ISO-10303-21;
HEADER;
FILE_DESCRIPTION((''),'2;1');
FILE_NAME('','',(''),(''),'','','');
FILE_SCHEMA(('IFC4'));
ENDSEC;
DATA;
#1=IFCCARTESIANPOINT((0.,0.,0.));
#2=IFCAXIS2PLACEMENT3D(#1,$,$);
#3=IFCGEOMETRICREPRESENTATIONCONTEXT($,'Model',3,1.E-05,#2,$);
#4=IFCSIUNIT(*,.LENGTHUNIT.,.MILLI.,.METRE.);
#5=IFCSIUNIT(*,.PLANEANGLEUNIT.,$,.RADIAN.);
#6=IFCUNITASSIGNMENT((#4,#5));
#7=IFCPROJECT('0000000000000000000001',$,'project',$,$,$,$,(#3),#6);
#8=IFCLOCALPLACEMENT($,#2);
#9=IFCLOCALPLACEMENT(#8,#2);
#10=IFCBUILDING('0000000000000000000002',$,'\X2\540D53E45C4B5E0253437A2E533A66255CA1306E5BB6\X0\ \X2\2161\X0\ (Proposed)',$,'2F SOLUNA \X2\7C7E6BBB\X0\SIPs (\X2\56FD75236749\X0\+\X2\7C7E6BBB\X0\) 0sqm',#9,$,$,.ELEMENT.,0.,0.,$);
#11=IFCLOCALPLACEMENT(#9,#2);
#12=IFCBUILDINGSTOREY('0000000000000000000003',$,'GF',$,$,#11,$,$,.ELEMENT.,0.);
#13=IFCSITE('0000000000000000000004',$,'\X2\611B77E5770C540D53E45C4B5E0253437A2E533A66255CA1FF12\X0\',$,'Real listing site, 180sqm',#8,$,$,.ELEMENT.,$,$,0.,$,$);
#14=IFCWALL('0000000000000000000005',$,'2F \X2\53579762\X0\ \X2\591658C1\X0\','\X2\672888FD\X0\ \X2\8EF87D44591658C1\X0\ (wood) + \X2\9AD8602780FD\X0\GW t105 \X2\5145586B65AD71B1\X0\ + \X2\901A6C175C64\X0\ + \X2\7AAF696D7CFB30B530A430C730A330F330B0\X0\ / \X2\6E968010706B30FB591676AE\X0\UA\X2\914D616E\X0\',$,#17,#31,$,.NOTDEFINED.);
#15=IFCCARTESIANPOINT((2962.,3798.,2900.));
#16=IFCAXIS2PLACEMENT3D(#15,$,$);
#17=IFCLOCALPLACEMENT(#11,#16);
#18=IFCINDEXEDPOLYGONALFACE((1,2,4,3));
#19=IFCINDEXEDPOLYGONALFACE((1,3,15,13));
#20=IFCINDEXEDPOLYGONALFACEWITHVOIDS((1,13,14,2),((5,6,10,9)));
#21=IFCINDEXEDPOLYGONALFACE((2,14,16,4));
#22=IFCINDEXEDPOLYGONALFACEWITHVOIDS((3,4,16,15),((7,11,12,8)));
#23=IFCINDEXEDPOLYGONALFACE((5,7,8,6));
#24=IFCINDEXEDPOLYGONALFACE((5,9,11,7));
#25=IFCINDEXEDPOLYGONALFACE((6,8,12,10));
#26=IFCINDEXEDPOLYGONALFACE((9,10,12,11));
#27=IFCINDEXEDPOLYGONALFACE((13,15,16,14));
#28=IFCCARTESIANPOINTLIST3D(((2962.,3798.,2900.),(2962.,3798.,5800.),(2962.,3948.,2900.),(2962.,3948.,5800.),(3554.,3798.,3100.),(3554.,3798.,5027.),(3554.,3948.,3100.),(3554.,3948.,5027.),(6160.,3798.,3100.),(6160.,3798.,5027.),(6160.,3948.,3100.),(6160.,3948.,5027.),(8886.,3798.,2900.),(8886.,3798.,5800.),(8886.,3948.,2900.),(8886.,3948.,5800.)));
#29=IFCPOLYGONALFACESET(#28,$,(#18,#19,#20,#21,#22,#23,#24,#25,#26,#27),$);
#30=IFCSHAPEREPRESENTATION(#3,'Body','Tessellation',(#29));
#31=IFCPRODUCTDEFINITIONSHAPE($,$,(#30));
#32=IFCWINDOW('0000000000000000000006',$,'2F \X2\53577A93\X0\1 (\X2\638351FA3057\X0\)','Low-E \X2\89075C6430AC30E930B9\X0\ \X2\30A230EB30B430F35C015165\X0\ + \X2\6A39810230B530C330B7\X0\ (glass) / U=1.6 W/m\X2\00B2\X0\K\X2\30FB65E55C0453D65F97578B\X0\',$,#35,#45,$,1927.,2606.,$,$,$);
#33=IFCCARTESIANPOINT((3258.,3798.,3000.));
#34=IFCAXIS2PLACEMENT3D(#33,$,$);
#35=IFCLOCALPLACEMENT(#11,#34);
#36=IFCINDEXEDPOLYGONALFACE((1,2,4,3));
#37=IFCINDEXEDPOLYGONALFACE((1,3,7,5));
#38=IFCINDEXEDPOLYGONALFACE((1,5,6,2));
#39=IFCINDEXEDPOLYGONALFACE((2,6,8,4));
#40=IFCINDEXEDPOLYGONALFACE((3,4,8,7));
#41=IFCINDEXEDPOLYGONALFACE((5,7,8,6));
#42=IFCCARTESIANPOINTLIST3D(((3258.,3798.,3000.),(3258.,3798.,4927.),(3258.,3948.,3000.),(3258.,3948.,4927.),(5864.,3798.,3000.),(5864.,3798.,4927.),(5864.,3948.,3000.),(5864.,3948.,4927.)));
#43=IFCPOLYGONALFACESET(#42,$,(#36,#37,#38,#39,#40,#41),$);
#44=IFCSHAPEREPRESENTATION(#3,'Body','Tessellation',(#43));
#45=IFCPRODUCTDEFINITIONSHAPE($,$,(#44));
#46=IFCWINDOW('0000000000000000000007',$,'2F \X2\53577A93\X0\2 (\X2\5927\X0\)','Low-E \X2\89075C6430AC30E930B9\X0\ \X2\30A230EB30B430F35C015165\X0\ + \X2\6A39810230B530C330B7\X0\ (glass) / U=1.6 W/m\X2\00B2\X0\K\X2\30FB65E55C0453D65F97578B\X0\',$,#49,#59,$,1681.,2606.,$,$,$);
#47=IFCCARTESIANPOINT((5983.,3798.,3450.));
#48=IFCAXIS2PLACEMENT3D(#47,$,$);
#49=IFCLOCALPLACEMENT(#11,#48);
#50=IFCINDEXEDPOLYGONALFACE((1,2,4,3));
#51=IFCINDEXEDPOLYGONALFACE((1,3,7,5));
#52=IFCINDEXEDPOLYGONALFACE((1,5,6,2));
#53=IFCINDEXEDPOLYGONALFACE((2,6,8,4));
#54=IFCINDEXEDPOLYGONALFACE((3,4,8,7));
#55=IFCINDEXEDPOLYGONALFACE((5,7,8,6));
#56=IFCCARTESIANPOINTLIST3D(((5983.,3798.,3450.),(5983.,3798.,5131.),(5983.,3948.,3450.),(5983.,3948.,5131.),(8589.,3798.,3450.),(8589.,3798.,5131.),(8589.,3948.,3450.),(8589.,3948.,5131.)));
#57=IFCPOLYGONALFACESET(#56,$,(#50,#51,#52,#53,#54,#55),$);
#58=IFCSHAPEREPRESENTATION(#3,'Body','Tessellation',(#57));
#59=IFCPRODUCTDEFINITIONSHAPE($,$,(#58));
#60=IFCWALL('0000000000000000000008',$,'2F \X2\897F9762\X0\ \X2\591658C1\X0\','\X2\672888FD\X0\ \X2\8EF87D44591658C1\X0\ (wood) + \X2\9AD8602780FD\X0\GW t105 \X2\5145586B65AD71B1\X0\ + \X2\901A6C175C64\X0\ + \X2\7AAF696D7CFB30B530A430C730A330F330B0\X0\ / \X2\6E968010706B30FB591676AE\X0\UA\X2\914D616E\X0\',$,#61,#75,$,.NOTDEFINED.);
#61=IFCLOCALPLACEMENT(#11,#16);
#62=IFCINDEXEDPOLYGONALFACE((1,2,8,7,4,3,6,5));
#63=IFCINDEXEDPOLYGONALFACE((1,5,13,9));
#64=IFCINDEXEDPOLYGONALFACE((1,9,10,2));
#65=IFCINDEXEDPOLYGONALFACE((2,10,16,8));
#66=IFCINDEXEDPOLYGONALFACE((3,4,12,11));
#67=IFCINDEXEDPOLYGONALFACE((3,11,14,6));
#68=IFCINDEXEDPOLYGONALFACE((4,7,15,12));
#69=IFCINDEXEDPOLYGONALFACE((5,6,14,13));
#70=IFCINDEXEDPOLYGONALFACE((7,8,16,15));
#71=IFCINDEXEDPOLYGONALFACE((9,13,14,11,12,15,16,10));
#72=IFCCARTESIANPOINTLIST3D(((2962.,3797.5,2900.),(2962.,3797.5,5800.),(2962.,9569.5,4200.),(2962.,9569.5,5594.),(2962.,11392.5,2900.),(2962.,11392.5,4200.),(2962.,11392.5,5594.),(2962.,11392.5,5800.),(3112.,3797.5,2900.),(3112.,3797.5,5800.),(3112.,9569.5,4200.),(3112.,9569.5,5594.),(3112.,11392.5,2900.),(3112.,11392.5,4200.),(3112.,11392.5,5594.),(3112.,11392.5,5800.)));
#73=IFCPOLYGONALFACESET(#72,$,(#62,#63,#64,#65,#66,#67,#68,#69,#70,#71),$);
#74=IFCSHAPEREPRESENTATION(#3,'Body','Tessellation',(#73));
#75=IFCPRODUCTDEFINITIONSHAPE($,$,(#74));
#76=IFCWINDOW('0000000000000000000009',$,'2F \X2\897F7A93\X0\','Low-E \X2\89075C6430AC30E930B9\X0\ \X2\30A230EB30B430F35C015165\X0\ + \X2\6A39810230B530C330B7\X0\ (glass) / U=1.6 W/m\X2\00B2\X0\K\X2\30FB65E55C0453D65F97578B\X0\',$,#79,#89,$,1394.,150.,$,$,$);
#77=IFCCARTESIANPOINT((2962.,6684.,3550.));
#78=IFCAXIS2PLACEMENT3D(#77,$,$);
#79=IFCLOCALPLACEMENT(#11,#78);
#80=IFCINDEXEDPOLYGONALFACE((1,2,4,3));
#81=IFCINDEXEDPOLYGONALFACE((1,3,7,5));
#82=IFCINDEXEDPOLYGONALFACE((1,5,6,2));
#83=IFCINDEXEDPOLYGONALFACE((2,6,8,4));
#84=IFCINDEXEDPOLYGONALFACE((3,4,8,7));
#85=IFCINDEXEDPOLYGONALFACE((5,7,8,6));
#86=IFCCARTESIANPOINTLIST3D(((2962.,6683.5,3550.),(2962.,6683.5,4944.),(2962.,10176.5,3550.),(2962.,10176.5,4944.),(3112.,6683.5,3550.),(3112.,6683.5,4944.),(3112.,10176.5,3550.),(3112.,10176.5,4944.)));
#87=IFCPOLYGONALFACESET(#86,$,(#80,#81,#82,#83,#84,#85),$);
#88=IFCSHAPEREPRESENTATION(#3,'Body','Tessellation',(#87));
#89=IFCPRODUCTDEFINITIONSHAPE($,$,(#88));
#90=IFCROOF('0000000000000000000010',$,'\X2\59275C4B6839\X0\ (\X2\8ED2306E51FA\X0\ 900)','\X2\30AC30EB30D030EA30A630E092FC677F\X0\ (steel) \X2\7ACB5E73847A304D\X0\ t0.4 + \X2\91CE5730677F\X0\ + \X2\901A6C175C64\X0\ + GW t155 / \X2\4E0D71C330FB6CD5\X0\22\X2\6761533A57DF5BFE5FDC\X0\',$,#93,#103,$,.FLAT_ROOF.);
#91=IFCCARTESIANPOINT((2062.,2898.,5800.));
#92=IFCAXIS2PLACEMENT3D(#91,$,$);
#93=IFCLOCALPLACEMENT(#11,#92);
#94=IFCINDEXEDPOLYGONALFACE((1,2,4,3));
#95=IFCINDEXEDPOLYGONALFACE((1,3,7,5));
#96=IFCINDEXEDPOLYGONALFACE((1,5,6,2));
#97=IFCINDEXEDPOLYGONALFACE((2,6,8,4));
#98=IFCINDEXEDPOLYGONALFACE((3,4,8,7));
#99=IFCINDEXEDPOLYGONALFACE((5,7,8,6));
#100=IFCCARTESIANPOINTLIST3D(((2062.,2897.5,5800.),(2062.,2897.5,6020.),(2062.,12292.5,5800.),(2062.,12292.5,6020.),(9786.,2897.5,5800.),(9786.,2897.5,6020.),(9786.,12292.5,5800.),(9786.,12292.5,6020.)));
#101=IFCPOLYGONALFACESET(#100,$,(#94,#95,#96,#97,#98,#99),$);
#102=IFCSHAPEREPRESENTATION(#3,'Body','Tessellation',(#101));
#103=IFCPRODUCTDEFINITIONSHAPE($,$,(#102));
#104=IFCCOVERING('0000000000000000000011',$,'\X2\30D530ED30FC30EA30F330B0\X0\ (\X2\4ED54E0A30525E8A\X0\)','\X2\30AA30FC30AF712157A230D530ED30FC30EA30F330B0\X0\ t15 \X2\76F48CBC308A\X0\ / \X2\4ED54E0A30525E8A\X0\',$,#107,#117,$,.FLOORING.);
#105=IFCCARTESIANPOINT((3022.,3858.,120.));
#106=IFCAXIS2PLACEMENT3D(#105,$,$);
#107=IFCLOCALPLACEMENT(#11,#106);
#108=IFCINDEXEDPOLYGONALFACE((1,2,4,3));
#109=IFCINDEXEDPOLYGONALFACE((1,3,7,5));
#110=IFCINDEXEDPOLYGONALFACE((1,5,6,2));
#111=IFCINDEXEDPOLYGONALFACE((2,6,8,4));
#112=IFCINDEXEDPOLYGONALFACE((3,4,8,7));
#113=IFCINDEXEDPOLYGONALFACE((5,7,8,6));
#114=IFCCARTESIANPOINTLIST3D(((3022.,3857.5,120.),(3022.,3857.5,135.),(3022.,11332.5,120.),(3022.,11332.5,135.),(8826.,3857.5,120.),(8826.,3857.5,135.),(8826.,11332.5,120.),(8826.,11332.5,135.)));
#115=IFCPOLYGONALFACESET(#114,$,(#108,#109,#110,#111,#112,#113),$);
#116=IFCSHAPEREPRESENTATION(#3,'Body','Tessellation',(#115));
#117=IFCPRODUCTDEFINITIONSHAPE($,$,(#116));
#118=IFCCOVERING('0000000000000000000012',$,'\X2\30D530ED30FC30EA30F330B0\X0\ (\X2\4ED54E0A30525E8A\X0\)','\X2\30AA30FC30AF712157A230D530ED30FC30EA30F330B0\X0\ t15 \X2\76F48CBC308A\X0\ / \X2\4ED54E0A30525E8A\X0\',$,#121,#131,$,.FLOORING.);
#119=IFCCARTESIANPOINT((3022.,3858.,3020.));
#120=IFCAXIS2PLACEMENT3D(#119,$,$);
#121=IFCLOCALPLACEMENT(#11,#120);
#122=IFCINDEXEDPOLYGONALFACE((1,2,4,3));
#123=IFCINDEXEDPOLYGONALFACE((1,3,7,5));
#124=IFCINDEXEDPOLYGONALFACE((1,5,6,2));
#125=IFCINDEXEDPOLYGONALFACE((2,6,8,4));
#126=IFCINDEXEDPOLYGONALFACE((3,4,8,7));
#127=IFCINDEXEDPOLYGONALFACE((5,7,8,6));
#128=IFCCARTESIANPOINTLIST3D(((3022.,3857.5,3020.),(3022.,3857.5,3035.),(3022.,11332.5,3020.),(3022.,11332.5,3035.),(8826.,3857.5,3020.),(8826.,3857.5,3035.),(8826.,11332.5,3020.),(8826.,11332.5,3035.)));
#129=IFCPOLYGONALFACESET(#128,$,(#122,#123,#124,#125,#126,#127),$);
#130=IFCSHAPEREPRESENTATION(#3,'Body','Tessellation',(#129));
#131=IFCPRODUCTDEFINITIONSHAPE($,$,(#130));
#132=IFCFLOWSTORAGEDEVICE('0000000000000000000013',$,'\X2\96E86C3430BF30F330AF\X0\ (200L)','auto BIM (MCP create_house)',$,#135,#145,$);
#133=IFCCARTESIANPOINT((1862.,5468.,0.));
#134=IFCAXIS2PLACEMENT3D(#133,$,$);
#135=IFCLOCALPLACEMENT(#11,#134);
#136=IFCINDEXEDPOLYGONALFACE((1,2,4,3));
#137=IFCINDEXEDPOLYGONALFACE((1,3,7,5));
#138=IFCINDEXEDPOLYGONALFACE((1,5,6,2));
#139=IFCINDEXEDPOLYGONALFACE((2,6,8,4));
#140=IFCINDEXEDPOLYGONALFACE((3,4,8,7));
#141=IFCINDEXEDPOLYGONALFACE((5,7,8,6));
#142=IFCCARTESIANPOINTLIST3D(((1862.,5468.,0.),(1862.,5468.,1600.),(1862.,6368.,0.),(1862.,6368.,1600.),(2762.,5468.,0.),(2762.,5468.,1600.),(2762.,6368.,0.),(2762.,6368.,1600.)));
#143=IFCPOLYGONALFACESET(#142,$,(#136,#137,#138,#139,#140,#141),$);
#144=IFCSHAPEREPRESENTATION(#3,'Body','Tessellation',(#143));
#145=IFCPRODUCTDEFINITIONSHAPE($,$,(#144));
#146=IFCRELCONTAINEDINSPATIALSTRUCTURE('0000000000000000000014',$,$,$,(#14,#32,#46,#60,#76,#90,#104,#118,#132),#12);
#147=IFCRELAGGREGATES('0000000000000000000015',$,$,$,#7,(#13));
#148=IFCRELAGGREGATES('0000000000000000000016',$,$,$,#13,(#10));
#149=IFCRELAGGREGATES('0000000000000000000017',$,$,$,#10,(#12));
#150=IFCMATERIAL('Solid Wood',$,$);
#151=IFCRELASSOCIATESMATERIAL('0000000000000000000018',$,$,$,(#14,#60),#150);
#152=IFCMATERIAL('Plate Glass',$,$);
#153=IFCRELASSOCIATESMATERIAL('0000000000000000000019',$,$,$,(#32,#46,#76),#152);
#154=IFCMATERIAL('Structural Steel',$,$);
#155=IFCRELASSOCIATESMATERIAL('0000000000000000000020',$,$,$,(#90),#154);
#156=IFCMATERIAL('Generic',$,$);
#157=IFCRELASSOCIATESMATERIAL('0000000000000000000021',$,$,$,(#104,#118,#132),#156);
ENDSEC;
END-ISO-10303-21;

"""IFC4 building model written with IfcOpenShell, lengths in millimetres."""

from ifc_helpers import new_model, si_unit, frame, frame_2d, origin, place, context, project, spatial, rectangle, extrude, material, element, fill, save


model = new_model("IFC4")

# Units and contexts
model_context = context("Model", 3, precision=1e-05, world=origin())
ifc_project = project(units=[si_unit("LENGTHUNIT", "METRE", prefix="MILLI"), si_unit("PLANEANGLEUNIT", "RADIAN")], contexts=[model_context])

# Site, building, storey
site_placement = place(None, origin())
site = spatial("IfcSite", under=ifc_project, at=site_placement, Name="愛知県名古屋市千種区春岡２", ObjectType="Real listing site, 180sqm", CompositionType="ELEMENT", RefElevation=0.0)
building_placement = place(site_placement, origin())
building = spatial("IfcBuilding", under=site, at=building_placement, Name="名古屋市千種区春岡の家 Ⅱ (Proposed)", ObjectType="2F SOLUNA 籾殻SIPs (国産杉+籾殻) 0sqm", CompositionType="ELEMENT", ElevationOfRefHeight=0.0, ElevationOfTerrain=0.0)
storey_placement = place(building_placement, origin())
storey = spatial("IfcBuildingStorey", under=building, at=storey_placement, Name="GF", CompositionType="ELEMENT", Elevation=0.0)

# Shared definitions
ifc_material_1 = material(Name="Solid Wood")

# Shared definitions
ifc_material_2 = material(Name="Plate Glass")

# Wall, openings, windows
wall_1_placement = place(storey_placement, frame((2962.0, 3798.0, 2900.0)))
wall_1 = element("IfcWall", 1, at=wall_1_placement, inside=storey, material=ifc_material_1, Name="2F 南面 外壁", Description="木製 軸組外壁 (wood) + 高性能GW t105 充填断熱 + 通気層 + 窯業系サイディング / 準耐火・外皮UA配慮", PredefinedType="NOTDEFINED", context=model_context, shape_type="SweptSolid", body=[
    extrude(rectangle(XDim=5924.0, YDim=150.0, at=frame_2d((2962.0, 75.0))), frame((2962.0, 3798.0, 2900.0)), (0.0, 0.0, 1.0), 2900.0),
])
opening_1_placement = place(storey_placement, frame((3258.0, 3798.0, 3000.0)))
opening_1 = element("IfcOpeningElement", 2, at=opening_1_placement, cuts=wall_1, PredefinedType="NOTDEFINED", context=model_context, shape_type="SweptSolid", body=[
    extrude(rectangle(XDim=2606.0, YDim=150.0, at=frame_2d((1303.0, 75.0))), frame((3258.0, 3798.0, 3000.0)), (0.0, 0.0, 1.0), 1927.0),
])
opening_2_placement = place(storey_placement, frame((5983.0, 3798.0, 3450.0)))
opening_2 = element("IfcOpeningElement", 3, at=opening_2_placement, cuts=wall_1, PredefinedType="NOTDEFINED", context=model_context, shape_type="SweptSolid", body=[
    extrude(rectangle(XDim=2606.0, YDim=150.0, at=frame_2d((1303.0, 75.0))), frame((5983.0, 3798.0, 3450.0)), (0.0, 0.0, 1.0), 1681.0),
])
window_1_placement = place(storey_placement, frame((3258.0, 3798.0, 3000.0)))
window_1 = element("IfcWindow", 4, at=window_1_placement, inside=storey, material=ifc_material_2, Name="2F 南窓1 (掃出し)", Description="Low-E 複層ガラス アルゴン封入 + 樹脂サッシ (glass) / U=1.6 W/m²K・日射取得型", OverallHeight=1927.0, OverallWidth=2606.0, context=model_context, shape_type="SweptSolid", body=[
    extrude(rectangle(XDim=2606.0, YDim=150.0, at=frame_2d((1303.0, 75.0))), frame((3258.0, 3798.0, 3000.0)), (0.0, 0.0, 1.0), 1927.0),
])
fill(opening_1, window_1)
window_2_placement = place(storey_placement, frame((5983.0, 3798.0, 3450.0)))
window_2 = element("IfcWindow", 5, at=window_2_placement, inside=storey, material=ifc_material_2, Name="2F 南窓2 (大)", Description="Low-E 複層ガラス アルゴン封入 + 樹脂サッシ (glass) / U=1.6 W/m²K・日射取得型", OverallHeight=1681.0, OverallWidth=2606.0, context=model_context, shape_type="SweptSolid", body=[
    extrude(rectangle(XDim=2606.0, YDim=150.0, at=frame_2d((1303.0, 75.0))), frame((5983.0, 3798.0, 3450.0)), (0.0, 0.0, 1.0), 1681.0),
])
fill(opening_2, window_2)

# Wall, opening, window
wall_2_placement = place(storey_placement, frame((2962.0, 3798.0, 2900.0)))
wall_2 = element("IfcWall", 6, at=wall_2_placement, inside=storey, material=ifc_material_1, Name="2F 西面 外壁", Description="木製 軸組外壁 (wood) + 高性能GW t105 充填断熱 + 通気層 + 窯業系サイディング / 準耐火・外皮UA配慮", PredefinedType="NOTDEFINED", context=model_context, shape_type="SweptSolid", body=[
    extrude(rectangle(XDim=150.0, YDim=7595.0, at=frame_2d((75.0, 3797.0))), frame((2962.0, 3798.0, 2900.0)), (0.0, 0.0, 1.0), 2900.0),
])
opening_3_placement = place(storey_placement, frame((2962.0, 6684.0, 3550.0)))
opening_3 = element("IfcOpeningElement", 7, at=opening_3_placement, cuts=wall_2, PredefinedType="NOTDEFINED", context=model_context, shape_type="SweptSolid", body=[
    extrude(rectangle(XDim=150.0, YDim=3493.0, at=frame_2d((75.0, 1746.0))), frame((2962.0, 6684.0, 3550.0)), (0.0, 0.0, 1.0), 1394.0),
])
window_3_placement = place(storey_placement, frame((2962.0, 6684.0, 3550.0)))
window_3 = element("IfcWindow", 8, at=window_3_placement, inside=storey, material=ifc_material_2, Name="2F 西窓", Description="Low-E 複層ガラス アルゴン封入 + 樹脂サッシ (glass) / U=1.6 W/m²K・日射取得型", OverallHeight=1394.0, OverallWidth=150.0, context=model_context, shape_type="SweptSolid", body=[
    extrude(rectangle(XDim=150.0, YDim=3493.0, at=frame_2d((75.0, 1746.0))), frame((2962.0, 6684.0, 3550.0)), (0.0, 0.0, 1.0), 1394.0),
])
fill(opening_3, window_3)

# Roof
ifc_material_3 = material(Name="Structural Steel")
roof_placement = place(storey_placement, frame((2062.0, 2898.0, 5800.0)))
element("IfcRoof", 9, at=roof_placement, inside=storey, material=ifc_material_3, Name="大屋根 (軒の出 900)", Description="ガルバリウム鋼板 (steel) 立平葺き t0.4 + 野地板 + 通気層 + GW t155 / 不燃・法22条区域対応", PredefinedType="FLAT_ROOF", context=model_context, shape_type="SweptSolid", body=[
    extrude(rectangle(XDim=7724.0, YDim=9395.0, at=frame_2d((3862.0, 4697.0))), frame((2062.0, 2898.0, 5800.0)), (0.0, 0.0, 1.0), 220.0),
])

# Coverings
ifc_material_4 = material(Name="Generic")
covering_1_placement = place(storey_placement, frame((3022.0, 3858.0, 120.0)))
element("IfcCovering", 10, at=covering_1_placement, inside=storey, material=ifc_material_4, Name="フローリング (仕上げ床)", Description="オーク無垢フローリング t15 直貼り / 仕上げ床", PredefinedType="FLOORING", context=model_context, shape_type="SweptSolid", body=[
    extrude(rectangle(XDim=5804.0, YDim=7475.0, at=frame_2d((2902.0, 3737.0))), frame((3022.0, 3858.0, 120.0)), (0.0, 0.0, 1.0), 15.0),
])
covering_2_placement = place(storey_placement, frame((3022.0, 3858.0, 3020.0)))
element("IfcCovering", 11, at=covering_2_placement, inside=storey, material=ifc_material_4, Name="フローリング (仕上げ床)", Description="オーク無垢フローリング t15 直貼り / 仕上げ床", PredefinedType="FLOORING", context=model_context, shape_type="SweptSolid", body=[
    extrude(rectangle(XDim=5804.0, YDim=7475.0, at=frame_2d((2902.0, 3737.0))), frame((3022.0, 3858.0, 3020.0)), (0.0, 0.0, 1.0), 15.0),
])

# Flow storage device
flow_storage_device_placement = place(storey_placement, frame((1862.0, 5468.0, 0.0)))
element("IfcFlowStorageDevice", 12, at=flow_storage_device_placement, inside=storey, material=ifc_material_4, Name="雨水タンク (200L)", Description="auto BIM (MCP create_house)", context=model_context, shape_type="SweptSolid", body=[
    extrude(rectangle(XDim=900.0, YDim=900.0, at=frame_2d((450.0, 450.0))), frame((1862.0, 5468.0, 0.0)), (0.0, 0.0, 1.0), 1600.0),
])

save(model, "model.ifc")
